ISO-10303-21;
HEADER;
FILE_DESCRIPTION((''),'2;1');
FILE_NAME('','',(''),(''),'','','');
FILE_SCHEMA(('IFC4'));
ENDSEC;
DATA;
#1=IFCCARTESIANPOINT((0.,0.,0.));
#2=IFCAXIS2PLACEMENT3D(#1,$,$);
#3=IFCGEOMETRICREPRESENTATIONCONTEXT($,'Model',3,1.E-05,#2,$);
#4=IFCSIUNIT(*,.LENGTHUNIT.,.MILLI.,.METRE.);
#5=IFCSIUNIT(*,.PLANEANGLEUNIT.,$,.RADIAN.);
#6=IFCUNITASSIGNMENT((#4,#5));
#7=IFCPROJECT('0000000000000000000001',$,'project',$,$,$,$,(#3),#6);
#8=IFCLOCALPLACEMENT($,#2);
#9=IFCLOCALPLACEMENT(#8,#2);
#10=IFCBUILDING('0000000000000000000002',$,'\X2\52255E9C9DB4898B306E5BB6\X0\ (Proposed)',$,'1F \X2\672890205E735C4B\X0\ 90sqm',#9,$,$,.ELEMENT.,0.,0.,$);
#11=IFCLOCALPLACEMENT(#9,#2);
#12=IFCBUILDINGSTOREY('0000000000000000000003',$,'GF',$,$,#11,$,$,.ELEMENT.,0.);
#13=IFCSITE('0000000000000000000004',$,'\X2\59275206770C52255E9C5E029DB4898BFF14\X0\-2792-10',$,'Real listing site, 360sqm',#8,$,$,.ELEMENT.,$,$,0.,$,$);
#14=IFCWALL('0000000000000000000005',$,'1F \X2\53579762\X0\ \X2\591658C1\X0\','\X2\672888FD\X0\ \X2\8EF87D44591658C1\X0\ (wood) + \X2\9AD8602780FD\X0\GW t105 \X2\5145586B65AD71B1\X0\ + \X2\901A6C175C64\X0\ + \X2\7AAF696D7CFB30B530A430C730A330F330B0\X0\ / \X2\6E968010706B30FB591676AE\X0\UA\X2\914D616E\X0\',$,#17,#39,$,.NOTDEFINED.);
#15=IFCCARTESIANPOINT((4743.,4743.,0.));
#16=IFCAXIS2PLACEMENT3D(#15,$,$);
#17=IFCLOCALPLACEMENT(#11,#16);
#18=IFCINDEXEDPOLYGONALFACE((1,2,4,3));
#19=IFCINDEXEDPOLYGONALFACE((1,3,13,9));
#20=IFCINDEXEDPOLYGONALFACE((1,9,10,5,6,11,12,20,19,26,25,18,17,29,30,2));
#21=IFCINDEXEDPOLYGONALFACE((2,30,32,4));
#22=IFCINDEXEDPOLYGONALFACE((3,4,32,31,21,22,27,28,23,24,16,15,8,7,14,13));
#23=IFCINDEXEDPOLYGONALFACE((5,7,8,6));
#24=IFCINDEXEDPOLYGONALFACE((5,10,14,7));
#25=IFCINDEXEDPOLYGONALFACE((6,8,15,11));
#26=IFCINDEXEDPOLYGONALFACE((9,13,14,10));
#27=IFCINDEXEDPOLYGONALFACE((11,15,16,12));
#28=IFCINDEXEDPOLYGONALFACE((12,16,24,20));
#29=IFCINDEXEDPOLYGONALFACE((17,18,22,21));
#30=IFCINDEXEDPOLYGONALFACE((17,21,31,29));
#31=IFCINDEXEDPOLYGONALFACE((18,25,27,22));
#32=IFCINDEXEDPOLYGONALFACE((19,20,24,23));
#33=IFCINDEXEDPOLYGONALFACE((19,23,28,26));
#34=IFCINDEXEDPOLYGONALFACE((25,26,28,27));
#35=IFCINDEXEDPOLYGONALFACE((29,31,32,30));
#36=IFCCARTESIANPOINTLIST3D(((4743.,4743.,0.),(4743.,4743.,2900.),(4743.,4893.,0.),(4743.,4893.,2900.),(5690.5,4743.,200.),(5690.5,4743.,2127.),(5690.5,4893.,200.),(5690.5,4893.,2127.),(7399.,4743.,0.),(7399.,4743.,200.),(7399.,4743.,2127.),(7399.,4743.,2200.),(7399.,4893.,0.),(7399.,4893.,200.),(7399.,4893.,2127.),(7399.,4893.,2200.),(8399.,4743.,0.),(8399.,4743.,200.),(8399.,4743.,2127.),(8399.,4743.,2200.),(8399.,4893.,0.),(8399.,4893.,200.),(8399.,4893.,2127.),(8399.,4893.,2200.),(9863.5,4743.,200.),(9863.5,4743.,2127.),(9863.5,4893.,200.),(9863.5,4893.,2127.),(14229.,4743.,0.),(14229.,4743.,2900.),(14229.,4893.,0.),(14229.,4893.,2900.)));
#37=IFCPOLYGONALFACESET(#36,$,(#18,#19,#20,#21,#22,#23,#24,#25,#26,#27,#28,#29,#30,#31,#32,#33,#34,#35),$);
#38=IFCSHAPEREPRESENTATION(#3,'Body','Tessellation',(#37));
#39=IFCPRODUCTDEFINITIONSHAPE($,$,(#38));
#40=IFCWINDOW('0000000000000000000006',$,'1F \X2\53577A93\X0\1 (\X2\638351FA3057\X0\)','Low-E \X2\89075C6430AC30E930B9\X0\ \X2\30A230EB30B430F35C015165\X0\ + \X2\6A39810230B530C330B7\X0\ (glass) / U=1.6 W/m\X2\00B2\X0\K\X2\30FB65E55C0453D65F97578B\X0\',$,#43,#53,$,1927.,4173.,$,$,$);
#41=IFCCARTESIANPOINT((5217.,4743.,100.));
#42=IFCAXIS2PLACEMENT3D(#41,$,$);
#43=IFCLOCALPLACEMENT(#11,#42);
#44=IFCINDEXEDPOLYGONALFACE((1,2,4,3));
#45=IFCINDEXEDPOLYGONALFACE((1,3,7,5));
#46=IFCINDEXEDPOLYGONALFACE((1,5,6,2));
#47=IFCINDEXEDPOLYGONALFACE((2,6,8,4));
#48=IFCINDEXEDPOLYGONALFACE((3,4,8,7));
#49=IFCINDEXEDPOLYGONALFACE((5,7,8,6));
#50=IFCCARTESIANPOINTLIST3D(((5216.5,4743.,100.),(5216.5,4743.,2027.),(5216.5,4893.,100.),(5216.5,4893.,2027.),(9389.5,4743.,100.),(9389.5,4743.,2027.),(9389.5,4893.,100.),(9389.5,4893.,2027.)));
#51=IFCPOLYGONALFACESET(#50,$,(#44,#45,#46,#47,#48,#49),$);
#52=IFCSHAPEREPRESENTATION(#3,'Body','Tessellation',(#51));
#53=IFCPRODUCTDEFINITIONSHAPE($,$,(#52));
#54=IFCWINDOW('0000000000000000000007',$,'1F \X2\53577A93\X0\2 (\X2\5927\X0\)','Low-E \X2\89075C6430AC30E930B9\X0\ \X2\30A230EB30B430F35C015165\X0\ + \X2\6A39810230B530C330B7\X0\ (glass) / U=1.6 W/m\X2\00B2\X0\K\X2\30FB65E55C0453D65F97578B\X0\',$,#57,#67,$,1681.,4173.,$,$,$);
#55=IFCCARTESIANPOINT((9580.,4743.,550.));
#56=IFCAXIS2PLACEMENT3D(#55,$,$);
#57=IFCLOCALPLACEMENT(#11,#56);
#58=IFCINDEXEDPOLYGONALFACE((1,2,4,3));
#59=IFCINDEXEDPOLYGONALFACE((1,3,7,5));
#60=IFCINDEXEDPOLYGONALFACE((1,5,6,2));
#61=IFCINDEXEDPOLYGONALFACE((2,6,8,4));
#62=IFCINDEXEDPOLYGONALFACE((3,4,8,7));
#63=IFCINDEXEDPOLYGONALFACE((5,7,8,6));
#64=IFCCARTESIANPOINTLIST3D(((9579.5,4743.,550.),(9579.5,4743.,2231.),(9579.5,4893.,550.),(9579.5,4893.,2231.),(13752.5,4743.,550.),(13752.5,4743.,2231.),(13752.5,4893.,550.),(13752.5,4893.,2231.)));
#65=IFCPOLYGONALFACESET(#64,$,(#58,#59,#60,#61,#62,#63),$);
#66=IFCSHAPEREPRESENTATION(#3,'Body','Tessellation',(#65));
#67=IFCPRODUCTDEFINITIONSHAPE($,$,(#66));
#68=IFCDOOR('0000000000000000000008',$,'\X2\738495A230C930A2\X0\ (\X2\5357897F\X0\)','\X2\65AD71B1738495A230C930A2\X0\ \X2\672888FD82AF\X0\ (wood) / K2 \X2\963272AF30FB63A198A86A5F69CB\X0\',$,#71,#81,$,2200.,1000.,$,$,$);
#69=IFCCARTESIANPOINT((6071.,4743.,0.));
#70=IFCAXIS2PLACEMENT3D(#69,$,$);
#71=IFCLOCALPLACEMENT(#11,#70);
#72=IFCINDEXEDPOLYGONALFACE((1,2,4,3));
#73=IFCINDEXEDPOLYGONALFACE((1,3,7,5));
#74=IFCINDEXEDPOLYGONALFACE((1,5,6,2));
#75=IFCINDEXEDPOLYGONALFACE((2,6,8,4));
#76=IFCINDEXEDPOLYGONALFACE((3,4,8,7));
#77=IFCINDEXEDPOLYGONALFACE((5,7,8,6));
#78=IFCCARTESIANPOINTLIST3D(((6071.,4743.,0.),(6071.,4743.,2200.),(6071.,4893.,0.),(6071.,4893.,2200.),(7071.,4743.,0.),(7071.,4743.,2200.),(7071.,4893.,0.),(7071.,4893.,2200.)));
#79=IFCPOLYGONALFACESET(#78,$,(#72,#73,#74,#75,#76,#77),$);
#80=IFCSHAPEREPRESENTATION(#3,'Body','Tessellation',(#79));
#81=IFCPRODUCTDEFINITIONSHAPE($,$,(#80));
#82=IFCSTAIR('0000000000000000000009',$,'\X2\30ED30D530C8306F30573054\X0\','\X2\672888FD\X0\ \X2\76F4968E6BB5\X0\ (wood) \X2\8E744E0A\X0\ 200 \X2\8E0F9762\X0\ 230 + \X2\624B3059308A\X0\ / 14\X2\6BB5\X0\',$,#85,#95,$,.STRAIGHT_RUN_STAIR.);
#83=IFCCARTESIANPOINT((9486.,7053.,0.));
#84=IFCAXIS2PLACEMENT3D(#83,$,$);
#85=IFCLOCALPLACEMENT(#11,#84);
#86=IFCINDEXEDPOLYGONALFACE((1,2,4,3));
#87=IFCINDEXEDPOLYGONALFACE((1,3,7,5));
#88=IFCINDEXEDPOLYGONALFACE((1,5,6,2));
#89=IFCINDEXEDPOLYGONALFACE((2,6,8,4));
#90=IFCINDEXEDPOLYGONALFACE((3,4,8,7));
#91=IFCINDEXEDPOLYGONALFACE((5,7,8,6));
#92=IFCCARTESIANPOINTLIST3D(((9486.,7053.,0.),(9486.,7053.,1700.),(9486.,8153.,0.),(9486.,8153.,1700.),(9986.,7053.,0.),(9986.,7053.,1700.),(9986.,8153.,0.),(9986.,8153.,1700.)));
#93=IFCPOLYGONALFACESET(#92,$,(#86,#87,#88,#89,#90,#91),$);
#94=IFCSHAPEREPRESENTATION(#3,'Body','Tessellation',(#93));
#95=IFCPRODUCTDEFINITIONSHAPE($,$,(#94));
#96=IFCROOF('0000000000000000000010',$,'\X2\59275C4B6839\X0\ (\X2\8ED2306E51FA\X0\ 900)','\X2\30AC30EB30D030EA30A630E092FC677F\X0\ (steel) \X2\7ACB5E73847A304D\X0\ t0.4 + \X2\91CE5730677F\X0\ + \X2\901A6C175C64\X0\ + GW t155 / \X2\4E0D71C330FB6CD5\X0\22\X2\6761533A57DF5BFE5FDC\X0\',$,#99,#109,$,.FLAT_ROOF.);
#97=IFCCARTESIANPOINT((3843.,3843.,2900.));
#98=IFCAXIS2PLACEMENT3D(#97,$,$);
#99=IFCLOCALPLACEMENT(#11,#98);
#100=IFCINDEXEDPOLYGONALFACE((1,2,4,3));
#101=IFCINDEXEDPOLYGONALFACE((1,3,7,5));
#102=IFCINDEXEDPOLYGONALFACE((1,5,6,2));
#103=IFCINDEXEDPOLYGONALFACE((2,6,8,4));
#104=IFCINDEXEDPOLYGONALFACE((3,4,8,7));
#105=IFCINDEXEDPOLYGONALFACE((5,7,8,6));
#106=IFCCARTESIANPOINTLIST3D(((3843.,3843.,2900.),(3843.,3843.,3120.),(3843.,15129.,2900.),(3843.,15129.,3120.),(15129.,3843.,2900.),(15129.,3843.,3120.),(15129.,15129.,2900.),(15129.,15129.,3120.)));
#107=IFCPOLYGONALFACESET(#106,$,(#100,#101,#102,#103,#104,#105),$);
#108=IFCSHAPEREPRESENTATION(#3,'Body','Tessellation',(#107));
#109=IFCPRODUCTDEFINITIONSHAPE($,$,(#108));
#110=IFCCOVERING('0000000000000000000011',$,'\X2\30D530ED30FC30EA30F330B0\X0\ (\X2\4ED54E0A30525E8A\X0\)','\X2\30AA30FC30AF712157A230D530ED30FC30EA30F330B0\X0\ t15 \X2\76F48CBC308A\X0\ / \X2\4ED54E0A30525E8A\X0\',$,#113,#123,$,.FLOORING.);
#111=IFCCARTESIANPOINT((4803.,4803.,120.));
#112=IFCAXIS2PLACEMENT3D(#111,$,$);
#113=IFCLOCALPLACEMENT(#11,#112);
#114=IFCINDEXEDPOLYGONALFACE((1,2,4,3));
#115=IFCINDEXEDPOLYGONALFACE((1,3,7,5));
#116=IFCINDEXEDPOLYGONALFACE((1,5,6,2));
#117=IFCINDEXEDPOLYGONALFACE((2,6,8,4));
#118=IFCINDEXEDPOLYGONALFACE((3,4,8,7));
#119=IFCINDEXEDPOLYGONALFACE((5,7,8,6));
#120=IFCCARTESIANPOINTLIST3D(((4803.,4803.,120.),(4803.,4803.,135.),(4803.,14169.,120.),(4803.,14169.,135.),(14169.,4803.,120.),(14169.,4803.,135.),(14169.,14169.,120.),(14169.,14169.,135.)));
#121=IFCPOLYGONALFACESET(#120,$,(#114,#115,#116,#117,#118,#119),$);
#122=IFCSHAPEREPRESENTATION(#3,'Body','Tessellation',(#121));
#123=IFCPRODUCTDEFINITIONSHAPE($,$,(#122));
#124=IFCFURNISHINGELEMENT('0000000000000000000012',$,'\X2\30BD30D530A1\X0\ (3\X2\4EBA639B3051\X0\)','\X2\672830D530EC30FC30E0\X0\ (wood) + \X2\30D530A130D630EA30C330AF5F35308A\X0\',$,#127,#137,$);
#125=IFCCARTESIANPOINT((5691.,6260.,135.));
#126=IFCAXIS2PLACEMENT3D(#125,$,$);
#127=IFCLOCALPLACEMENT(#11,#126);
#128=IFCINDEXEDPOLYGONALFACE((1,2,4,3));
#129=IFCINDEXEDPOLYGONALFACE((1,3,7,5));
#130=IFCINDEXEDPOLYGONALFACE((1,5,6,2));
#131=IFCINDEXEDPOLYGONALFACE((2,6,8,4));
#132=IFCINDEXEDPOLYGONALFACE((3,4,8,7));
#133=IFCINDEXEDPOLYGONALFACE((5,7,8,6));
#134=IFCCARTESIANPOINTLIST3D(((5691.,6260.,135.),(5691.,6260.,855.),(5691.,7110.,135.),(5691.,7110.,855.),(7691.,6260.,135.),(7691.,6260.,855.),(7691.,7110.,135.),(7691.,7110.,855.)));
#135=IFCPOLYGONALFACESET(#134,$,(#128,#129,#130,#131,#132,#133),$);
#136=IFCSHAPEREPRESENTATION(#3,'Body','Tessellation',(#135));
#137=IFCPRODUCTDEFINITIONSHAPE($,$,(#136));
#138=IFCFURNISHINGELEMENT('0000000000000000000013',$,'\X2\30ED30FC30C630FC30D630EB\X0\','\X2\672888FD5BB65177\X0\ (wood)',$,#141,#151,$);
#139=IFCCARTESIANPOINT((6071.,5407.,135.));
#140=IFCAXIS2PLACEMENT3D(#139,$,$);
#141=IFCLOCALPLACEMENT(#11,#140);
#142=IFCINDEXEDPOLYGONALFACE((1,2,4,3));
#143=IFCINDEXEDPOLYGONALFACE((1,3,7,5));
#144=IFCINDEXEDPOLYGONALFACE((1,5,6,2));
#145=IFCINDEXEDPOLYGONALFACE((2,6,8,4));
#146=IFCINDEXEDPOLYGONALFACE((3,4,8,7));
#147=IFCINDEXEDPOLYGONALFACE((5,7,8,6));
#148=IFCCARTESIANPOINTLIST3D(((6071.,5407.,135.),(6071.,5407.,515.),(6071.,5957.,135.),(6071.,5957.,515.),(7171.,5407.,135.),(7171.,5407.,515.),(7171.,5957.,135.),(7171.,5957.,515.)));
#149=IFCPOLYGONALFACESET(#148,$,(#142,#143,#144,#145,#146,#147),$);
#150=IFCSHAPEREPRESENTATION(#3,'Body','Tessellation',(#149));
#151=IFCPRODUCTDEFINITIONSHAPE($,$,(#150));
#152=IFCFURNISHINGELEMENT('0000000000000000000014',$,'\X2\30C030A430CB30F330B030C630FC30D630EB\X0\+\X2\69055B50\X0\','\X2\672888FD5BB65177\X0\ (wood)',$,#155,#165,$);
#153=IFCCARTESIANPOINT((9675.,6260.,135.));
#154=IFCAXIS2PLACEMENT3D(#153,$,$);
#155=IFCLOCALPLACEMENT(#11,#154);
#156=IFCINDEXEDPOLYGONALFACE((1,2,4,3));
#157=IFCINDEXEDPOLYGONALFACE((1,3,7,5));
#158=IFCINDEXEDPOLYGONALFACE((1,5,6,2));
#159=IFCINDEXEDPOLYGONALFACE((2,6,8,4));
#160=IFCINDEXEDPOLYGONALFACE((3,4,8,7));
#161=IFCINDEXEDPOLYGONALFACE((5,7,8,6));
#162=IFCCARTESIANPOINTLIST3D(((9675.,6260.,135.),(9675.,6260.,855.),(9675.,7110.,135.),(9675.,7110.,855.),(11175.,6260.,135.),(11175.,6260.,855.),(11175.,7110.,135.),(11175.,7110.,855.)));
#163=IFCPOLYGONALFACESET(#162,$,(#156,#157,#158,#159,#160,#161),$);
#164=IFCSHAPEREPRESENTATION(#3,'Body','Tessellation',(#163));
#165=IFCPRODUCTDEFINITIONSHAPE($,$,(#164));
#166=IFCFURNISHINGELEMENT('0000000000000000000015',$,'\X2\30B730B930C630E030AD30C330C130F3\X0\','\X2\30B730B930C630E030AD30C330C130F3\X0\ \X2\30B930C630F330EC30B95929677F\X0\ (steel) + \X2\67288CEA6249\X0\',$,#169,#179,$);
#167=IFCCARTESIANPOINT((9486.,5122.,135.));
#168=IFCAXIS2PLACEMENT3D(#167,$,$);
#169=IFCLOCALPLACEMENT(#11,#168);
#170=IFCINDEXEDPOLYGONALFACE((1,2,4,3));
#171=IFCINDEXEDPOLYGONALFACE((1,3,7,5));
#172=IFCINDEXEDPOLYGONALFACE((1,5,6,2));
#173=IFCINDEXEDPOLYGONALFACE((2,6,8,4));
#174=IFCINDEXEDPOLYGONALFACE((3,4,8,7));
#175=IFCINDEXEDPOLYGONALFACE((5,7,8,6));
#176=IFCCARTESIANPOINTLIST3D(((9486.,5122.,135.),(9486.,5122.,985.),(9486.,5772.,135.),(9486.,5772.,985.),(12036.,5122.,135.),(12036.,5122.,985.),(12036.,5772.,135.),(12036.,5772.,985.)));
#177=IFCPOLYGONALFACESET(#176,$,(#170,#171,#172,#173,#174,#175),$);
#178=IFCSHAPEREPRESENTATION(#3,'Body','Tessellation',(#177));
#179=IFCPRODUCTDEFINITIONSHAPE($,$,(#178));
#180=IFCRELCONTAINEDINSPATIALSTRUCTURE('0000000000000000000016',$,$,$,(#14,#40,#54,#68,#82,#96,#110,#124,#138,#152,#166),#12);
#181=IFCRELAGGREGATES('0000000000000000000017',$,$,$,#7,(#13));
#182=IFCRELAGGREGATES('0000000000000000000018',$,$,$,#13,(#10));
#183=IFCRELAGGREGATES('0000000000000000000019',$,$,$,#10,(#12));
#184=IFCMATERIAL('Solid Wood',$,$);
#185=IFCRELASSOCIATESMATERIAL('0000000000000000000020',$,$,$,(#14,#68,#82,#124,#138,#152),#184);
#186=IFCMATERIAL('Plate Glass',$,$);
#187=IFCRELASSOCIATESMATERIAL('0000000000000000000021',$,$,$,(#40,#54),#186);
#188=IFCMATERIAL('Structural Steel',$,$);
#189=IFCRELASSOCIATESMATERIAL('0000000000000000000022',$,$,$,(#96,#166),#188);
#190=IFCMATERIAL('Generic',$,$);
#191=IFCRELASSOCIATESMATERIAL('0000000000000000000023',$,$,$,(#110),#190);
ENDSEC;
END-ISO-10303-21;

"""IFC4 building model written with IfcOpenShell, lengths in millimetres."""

from ifc_helpers import new_model, si_unit, frame, frame_2d, origin, place, context, project, spatial, rectangle, extrude, material, element, fill, save


model = new_model("IFC4")

# Units and contexts
model_context = context("Model", 3, precision=1e-05, world=origin())
ifc_project = project(units=[si_unit("LENGTHUNIT", "METRE", prefix="MILLI"), si_unit("PLANEANGLEUNIT", "RADIAN")], contexts=[model_context])

# Site, building, storey
site_placement = place(None, origin())
site = spatial("IfcSite", under=ifc_project, at=site_placement, Name="大分県別府市鶴見４-2792-10", ObjectType="Real listing site, 360sqm", CompositionType="ELEMENT", RefElevation=0.0)
building_placement = place(site_placement, origin())
building = spatial("IfcBuilding", under=site, at=building_placement, Name="別府鶴見の家 (Proposed)", ObjectType="1F 木造平屋 90sqm", CompositionType="ELEMENT", ElevationOfRefHeight=0.0, ElevationOfTerrain=0.0)
storey_placement = place(building_placement, origin())
storey = spatial("IfcBuildingStorey", under=building, at=storey_placement, Name="GF", CompositionType="ELEMENT", Elevation=0.0)

# Shared definitions
ifc_material_1 = material(Name="Solid Wood")

# Wall, openings, windows, door
wall_1_placement = place(storey_placement, frame((4743.0, 4743.0, 0.0)))
wall_1 = element("IfcWall", 1, at=wall_1_placement, inside=storey, material=ifc_material_1, Name="1F 南面 外壁", Description="木製 軸組外壁 (wood) + 高性能GW t105 充填断熱 + 通気層 + 窯業系サイディング / 準耐火・外皮UA配慮", PredefinedType="NOTDEFINED", context=model_context, shape_type="SweptSolid", body=[
    extrude(rectangle(XDim=9486.0, YDim=150.0, at=frame_2d((4743.0, 75.0))), frame((4743.0, 4743.0, 0.0)), (0.0, 0.0, 1.0), 2900.0),
])
opening_1_placement = place(storey_placement, frame((5217.0, 4743.0, 100.0)))
opening_1 = element("IfcOpeningElement", 2, at=opening_1_placement, cuts=wall_1, PredefinedType="NOTDEFINED", context=model_context, shape_type="SweptSolid", body=[
    extrude(rectangle(XDim=4173.0, YDim=150.0, at=frame_2d((2086.0, 75.0))), frame((5217.0, 4743.0, 100.0)), (0.0, 0.0, 1.0), 1927.0),
])
opening_2_placement = place(storey_placement, frame((9580.0, 4743.0, 550.0)))
opening_2 = element("IfcOpeningElement", 3, at=opening_2_placement, cuts=wall_1, PredefinedType="NOTDEFINED", context=model_context, shape_type="SweptSolid", body=[
    extrude(rectangle(XDim=4173.0, YDim=150.0, at=frame_2d((2086.0, 75.0))), frame((9580.0, 4743.0, 550.0)), (0.0, 0.0, 1.0), 1681.0),
])
opening_3_placement = place(storey_placement, frame((6071.0, 4743.0, 0.0)))
opening_3 = element("IfcOpeningElement", 4, at=opening_3_placement, cuts=wall_1, PredefinedType="NOTDEFINED", context=model_context, shape_type="SweptSolid", body=[
    extrude(rectangle(XDim=1000.0, YDim=150.0, at=frame_2d((500.0, 75.0))), frame((6071.0, 4743.0, 0.0)), (0.0, 0.0, 1.0), 2200.0),
])
ifc_material_2 = material(Name="Plate Glass")
window_1_placement = place(storey_placement, frame((5217.0, 4743.0, 100.0)))
window_1 = element("IfcWindow", 5, at=window_1_placement, inside=storey, material=ifc_material_2, Name="1F 南窓1 (掃出し)", Description="Low-E 複層ガラス アルゴン封入 + 樹脂サッシ (glass) / U=1.6 W/m²K・日射取得型", OverallHeight=1927.0, OverallWidth=4173.0, context=model_context, shape_type="SweptSolid", body=[
    extrude(rectangle(XDim=4173.0, YDim=150.0, at=frame_2d((2086.0, 75.0))), frame((5217.0, 4743.0, 100.0)), (0.0, 0.0, 1.0), 1927.0),
])
fill(opening_1, window_1)
window_2_placement = place(storey_placement, frame((9580.0, 4743.0, 550.0)))
window_2 = element("IfcWindow", 6, at=window_2_placement, inside=storey, material=ifc_material_2, Name="1F 南窓2 (大)", Description="Low-E 複層ガラス アルゴン封入 + 樹脂サッシ (glass) / U=1.6 W/m²K・日射取得型", OverallHeight=1681.0, OverallWidth=4173.0, context=model_context, shape_type="SweptSolid", body=[
    extrude(rectangle(XDim=4173.0, YDim=150.0, at=frame_2d((2086.0, 75.0))), frame((9580.0, 4743.0, 550.0)), (0.0, 0.0, 1.0), 1681.0),
])
fill(opening_2, window_2)
door_placement = place(storey_placement, frame((6071.0, 4743.0, 0.0)))
door = element("IfcDoor", 7, at=door_placement, inside=storey, material=ifc_material_1, Name="玄関ドア (南西)", Description="断熱玄関ドア 木製芯 (wood) / K2 防犯・採風機構", OverallHeight=2200.0, OverallWidth=1000.0, context=model_context, shape_type="SweptSolid", body=[
    extrude(rectangle(XDim=1000.0, YDim=150.0, at=frame_2d((500.0, 75.0))), frame((6071.0, 4743.0, 0.0)), (0.0, 0.0, 1.0), 2200.0),
])
fill(opening_3, door)

# Stair
stair_placement = place(storey_placement, frame((9486.0, 7053.0, 0.0)))
element("IfcStair", 8, at=stair_placement, inside=storey, material=ifc_material_1, Name="ロフトはしご", Description="木製 直階段 (wood) 蹴上 200 踏面 230 + 手すり / 14段", PredefinedType="STRAIGHT_RUN_STAIR", context=model_context, shape_type="SweptSolid", body=[
    extrude(rectangle(XDim=500.0, YDim=1100.0, at=frame_2d((250.0, 550.0))), frame((9486.0, 7053.0, 0.0)), (0.0, 0.0, 1.0), 1700.0),
])

# Roof
ifc_material_3 = material(Name="Structural Steel")
roof_placement = place(storey_placement, frame((3843.0, 3843.0, 2900.0)))
element("IfcRoof", 9, at=roof_placement, inside=storey, material=ifc_material_3, Name="大屋根 (軒の出 900)", Description="ガルバリウム鋼板 (steel) 立平葺き t0.4 + 野地板 + 通気層 + GW t155 / 不燃・法22条区域対応", PredefinedType="FLAT_ROOF", context=model_context, shape_type="SweptSolid", body=[
    extrude(rectangle(XDim=11286.0, YDim=11286.0, at=frame_2d((5643.0, 5643.0))), frame((3843.0, 3843.0, 2900.0)), (0.0, 0.0, 1.0), 220.0),
])

# Covering
ifc_material_4 = material(Name="Generic")
covering_placement = place(storey_placement, frame((4803.0, 4803.0, 120.0)))
element("IfcCovering", 10, at=covering_placement, inside=storey, material=ifc_material_4, Name="フローリング (仕上げ床)", Description="オーク無垢フローリング t15 直貼り / 仕上げ床", PredefinedType="FLOORING", context=model_context, shape_type="SweptSolid", body=[
    extrude(rectangle(XDim=9366.0, YDim=9366.0, at=frame_2d((4683.0, 4683.0))), frame((4803.0, 4803.0, 120.0)), (0.0, 0.0, 1.0), 15.0),
])

# Furnishing elements
furnishing_1_placement = place(storey_placement, frame((5691.0, 6260.0, 135.0)))
element("IfcFurnishingElement", 11, at=furnishing_1_placement, inside=storey, material=ifc_material_1, Name="ソファ (3人掛け)", Description="木フレーム (wood) + ファブリック張り", context=model_context, shape_type="SweptSolid", body=[
    extrude(rectangle(XDim=2000.0, YDim=850.0, at=frame_2d((1000.0, 425.0))), frame((5691.0, 6260.0, 135.0)), (0.0, 0.0, 1.0), 720.0),
])
furnishing_2_placement = place(storey_placement, frame((6071.0, 5407.0, 135.0)))
element("IfcFurnishingElement", 12, at=furnishing_2_placement, inside=storey, material=ifc_material_1, Name="ローテーブル", Description="木製家具 (wood)", context=model_context, shape_type="SweptSolid", body=[
    extrude(rectangle(XDim=1100.0, YDim=550.0, at=frame_2d((550.0, 275.0))), frame((6071.0, 5407.0, 135.0)), (0.0, 0.0, 1.0), 380.0),
])
furnishing_3_placement = place(storey_placement, frame((9675.0, 6260.0, 135.0)))
element("IfcFurnishingElement", 13, at=furnishing_3_placement, inside=storey, material=ifc_material_1, Name="ダイニングテーブル+椅子", Description="木製家具 (wood)", context=model_context, shape_type="SweptSolid", body=[
    extrude(rectangle(XDim=1500.0, YDim=850.0, at=frame_2d((750.0, 425.0))), frame((9675.0, 6260.0, 135.0)), (0.0, 0.0, 1.0), 720.0),
])
furnishing_4_placement = place(storey_placement, frame((9486.0, 5122.0, 135.0)))
element("IfcFurnishingElement", 14, at=furnishing_4_placement, inside=storey, material=ifc_material_3, Name="システムキッチン", Description="システムキッチン ステンレス天板 (steel) + 木質扉", context=model_context, shape_type="SweptSolid", body=[
    extrude(rectangle(XDim=2550.0, YDim=650.0, at=frame_2d((1275.0, 325.0))), frame((9486.0, 5122.0, 135.0)), (0.0, 0.0, 1.0), 850.0),
])

save(model, "model.ifc")
